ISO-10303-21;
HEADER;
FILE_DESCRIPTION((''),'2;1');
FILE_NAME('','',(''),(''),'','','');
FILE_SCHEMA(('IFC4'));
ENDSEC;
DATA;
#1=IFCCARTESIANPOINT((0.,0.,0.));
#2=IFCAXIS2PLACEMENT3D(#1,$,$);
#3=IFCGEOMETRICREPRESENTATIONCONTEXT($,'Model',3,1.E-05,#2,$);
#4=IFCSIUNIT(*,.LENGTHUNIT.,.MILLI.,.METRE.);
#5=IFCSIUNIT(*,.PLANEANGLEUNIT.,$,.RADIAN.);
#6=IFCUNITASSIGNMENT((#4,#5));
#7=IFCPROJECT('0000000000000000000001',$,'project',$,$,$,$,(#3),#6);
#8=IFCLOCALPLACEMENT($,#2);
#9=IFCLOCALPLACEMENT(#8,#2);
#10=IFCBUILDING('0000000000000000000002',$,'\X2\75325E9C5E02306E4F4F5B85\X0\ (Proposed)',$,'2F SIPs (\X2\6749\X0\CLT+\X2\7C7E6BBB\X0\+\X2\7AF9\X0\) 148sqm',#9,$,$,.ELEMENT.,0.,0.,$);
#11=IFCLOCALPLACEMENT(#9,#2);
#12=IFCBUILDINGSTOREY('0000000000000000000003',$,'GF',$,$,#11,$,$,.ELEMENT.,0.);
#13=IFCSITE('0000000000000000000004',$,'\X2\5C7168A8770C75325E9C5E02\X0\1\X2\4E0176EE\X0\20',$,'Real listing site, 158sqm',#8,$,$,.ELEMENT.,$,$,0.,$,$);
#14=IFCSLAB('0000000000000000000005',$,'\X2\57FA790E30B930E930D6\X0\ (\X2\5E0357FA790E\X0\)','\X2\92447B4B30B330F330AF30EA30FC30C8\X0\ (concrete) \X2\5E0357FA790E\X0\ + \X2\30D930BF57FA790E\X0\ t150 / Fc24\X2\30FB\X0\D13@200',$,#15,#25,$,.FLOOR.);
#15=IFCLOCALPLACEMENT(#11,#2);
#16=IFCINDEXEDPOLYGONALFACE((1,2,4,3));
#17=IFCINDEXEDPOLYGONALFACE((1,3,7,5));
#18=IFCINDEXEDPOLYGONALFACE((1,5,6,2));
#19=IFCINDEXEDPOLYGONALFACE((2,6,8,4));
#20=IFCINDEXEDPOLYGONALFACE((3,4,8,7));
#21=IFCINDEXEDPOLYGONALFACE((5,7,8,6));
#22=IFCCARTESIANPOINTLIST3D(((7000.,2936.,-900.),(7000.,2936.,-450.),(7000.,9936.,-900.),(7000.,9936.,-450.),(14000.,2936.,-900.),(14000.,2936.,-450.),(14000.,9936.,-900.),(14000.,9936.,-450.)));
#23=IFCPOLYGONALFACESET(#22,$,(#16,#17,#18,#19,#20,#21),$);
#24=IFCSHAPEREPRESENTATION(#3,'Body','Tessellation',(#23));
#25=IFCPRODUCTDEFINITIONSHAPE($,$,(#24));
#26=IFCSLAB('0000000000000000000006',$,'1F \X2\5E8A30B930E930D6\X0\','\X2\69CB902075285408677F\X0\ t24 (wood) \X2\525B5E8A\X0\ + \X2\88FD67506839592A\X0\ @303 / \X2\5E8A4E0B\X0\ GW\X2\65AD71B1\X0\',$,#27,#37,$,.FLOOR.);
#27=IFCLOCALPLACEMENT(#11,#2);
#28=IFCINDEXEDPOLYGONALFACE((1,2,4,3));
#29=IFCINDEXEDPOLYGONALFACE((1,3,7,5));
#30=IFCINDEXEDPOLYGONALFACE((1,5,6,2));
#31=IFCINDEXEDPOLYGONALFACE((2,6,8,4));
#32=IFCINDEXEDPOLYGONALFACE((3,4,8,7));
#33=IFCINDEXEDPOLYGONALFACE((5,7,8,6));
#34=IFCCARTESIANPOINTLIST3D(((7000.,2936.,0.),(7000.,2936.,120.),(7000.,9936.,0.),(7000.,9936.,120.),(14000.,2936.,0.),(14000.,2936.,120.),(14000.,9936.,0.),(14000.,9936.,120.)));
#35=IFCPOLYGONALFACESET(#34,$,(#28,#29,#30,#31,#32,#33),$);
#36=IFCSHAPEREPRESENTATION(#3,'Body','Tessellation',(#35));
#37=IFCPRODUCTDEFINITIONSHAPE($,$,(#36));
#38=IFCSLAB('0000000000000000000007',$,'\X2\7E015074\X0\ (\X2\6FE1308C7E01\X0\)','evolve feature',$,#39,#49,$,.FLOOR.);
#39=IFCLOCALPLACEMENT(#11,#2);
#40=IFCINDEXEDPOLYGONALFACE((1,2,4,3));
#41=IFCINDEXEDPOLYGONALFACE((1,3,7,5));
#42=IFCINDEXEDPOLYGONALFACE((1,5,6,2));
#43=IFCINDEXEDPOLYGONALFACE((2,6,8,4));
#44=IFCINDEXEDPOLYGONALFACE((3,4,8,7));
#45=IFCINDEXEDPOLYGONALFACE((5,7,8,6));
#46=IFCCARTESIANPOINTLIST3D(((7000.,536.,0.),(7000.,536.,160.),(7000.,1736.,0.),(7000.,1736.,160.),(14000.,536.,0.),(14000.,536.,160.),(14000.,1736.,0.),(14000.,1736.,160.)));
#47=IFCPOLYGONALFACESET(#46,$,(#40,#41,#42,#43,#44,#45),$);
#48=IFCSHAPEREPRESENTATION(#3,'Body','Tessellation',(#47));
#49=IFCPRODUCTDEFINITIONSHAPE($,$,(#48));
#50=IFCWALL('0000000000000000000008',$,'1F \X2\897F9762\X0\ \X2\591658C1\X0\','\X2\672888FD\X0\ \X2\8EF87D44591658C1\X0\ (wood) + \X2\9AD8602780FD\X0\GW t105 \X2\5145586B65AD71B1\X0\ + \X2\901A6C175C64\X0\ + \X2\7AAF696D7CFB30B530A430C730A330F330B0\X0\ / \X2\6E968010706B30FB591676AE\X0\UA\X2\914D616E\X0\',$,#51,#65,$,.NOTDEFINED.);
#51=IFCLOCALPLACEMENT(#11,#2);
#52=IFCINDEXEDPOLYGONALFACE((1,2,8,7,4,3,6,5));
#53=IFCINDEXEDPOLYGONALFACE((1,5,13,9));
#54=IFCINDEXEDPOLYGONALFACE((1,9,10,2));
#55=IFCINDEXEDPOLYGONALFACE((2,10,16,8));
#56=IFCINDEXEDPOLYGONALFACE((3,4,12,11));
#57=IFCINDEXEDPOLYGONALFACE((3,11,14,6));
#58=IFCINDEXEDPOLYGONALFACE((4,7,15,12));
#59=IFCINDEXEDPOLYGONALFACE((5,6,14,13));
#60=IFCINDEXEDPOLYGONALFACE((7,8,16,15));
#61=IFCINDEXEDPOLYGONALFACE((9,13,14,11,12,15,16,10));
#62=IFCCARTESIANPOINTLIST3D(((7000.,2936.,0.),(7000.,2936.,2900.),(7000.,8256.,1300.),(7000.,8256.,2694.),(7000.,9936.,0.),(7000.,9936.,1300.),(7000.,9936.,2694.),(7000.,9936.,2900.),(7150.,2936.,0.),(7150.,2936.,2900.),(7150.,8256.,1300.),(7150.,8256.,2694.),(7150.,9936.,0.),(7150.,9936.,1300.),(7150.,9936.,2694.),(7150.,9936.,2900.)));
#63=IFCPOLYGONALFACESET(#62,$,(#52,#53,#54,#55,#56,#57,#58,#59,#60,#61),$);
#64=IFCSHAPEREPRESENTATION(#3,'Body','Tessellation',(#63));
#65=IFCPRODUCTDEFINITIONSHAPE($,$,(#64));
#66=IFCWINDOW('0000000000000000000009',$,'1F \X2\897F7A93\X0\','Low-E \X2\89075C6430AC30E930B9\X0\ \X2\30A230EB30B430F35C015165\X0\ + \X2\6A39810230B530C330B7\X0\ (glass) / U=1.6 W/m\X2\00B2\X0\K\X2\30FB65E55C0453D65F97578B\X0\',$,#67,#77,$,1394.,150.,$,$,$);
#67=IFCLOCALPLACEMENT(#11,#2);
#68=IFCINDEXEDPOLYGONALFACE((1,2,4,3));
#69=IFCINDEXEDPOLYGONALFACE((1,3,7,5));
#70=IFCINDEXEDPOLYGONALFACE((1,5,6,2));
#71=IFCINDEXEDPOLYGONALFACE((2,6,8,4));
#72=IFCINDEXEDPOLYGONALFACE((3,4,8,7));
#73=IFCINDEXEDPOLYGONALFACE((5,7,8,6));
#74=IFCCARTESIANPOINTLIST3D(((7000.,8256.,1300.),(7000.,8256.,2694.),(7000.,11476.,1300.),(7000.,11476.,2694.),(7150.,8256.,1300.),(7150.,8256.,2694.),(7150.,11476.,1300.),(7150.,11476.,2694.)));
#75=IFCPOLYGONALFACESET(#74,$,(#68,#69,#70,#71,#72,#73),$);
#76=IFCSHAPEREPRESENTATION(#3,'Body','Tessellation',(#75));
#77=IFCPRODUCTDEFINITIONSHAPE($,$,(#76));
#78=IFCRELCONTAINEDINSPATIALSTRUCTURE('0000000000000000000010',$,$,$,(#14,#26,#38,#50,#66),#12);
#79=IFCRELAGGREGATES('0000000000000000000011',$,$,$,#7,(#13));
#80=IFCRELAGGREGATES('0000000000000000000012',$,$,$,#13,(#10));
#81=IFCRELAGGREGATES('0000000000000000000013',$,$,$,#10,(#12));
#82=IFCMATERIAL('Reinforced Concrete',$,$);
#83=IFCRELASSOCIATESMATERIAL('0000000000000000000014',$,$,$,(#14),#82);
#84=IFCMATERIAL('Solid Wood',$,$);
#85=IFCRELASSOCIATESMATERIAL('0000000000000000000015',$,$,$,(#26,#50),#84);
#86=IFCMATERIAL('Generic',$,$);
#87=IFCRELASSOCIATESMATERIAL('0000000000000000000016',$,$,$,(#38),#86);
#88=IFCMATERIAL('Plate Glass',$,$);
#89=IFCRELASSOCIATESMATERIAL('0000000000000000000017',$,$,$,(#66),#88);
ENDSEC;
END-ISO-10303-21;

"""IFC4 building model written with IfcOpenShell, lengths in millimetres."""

from ifc_helpers import new_model, si_unit, frame, frame_2d, origin, place, context, project, spatial, rectangle, extrude, material, element, fill, save


model = new_model("IFC4")

# Units and contexts
model_context = context("Model", 3, precision=1e-05, world=origin())
ifc_project = project(units=[si_unit("LENGTHUNIT", "METRE", prefix="MILLI"), si_unit("PLANEANGLEUNIT", "RADIAN")], contexts=[model_context])

# Site, building, storey
site_placement = place(None, origin())
site = spatial("IfcSite", under=ifc_project, at=site_placement, Name="山梨県甲府市1丁目20", ObjectType="Real listing site, 158sqm", CompositionType="ELEMENT", RefElevation=0.0)
building_placement = place(site_placement, origin())
building = spatial("IfcBuilding", under=site, at=building_placement, Name="甲府市の住宅 (Proposed)", ObjectType="2F SIPs (杉CLT+籾殻+竹) 148sqm", CompositionType="ELEMENT", ElevationOfRefHeight=0.0, ElevationOfTerrain=0.0)
storey_placement = place(building_placement, origin())
storey = spatial("IfcBuildingStorey", under=building, at=storey_placement, Name="GF", CompositionType="ELEMENT", Elevation=0.0)

# Slabs
ifc_material_1 = material(Name="Reinforced Concrete")
slab_1_placement = place(storey_placement, frame((3500.0, 1468.0, -450.0)))
element("IfcSlab", 1, at=slab_1_placement, inside=storey, material=ifc_material_1, Name="基礎スラブ (布基礎)", Description="鉄筋コンクリート (concrete) 布基礎 + ベタ基礎 t150 / Fc24・D13@200", PredefinedType="FLOOR", context=model_context, shape_type="SweptSolid", body=[
    extrude(rectangle(XDim=7000.0, YDim=7000.0, at=frame_2d((3500.0, 3500.0))), frame((3500.0, 1468.0, -450.0)), (0.0, 0.0, 1.0), 450.0),
])
ifc_material_2 = material(Name="Solid Wood")
slab_2_placement = place(storey_placement, frame((3500.0, 1468.0, 0.0)))
element("IfcSlab", 2, at=slab_2_placement, inside=storey, material=ifc_material_2, Name="1F 床スラブ", Description="構造用合板 t24 (wood) 剛床 + 製材根太 @303 / 床下 GW断熱", PredefinedType="FLOOR", context=model_context, shape_type="SweptSolid", body=[
    extrude(rectangle(XDim=7000.0, YDim=7000.0, at=frame_2d((3500.0, 3500.0))), frame((3500.0, 1468.0, 0.0)), (0.0, 0.0, 1.0), 120.0),
])
ifc_material_3 = material(Name="Generic")
slab_3_placement = place(storey_placement, frame((3500.0, 268.0, 0.0)))
element("IfcSlab", 3, at=slab_3_placement, inside=storey, material=ifc_material_3, Name="縁側 (濡れ縁)", Description="evolve feature", PredefinedType="FLOOR", context=model_context, shape_type="SweptSolid", body=[
    extrude(rectangle(XDim=7000.0, YDim=1200.0, at=frame_2d((3500.0, 600.0))), frame((3500.0, 268.0, 0.0)), (0.0, 0.0, 1.0), 160.0),
])

# Shared definitions
ifc_material_4 = material(Name="Plate Glass")

# Wall, opening, window
wall_1_placement = place(storey_placement, frame((3500.0, 1468.0, 0.0)))
wall_1 = element("IfcWall", 4, at=wall_1_placement, inside=storey, material=ifc_material_2, Name="1F 西面 外壁", Description="木製 軸組外壁 (wood) + 高性能GW t105 充填断熱 + 通気層 + 窯業系サイディング / 準耐火・外皮UA配慮", PredefinedType="NOTDEFINED", context=model_context, shape_type="SweptSolid", body=[
    extrude(rectangle(XDim=150.0, YDim=7000.0, at=frame_2d((75.0, 3500.0))), frame((3500.0, 1468.0, 0.0)), (0.0, 0.0, 1.0), 2900.0),
])
opening_1_placement = place(storey_placement, frame((3500.0, 4128.0, 650.0)))
opening_1 = element("IfcOpeningElement", 5, at=opening_1_placement, cuts=wall_1, PredefinedType="NOTDEFINED", context=model_context, shape_type="SweptSolid", body=[
    extrude(rectangle(XDim=150.0, YDim=3220.0, at=frame_2d((75.0, 1610.0))), frame((3500.0, 4128.0, 650.0)), (0.0, 0.0, 1.0), 1394.0),
])
window_1_placement = place(storey_placement, frame((3500.0, 4128.0, 650.0)))
window_1 = element("IfcWindow", 6, at=window_1_placement, inside=storey, material=ifc_material_4, Name="1F 西窓", Description="Low-E 複層ガラス アルゴン封入 + 樹脂サッシ (glass) / U=1.6 W/m²K・日射取得型", OverallHeight=1394.0, OverallWidth=150.0, context=model_context, shape_type="SweptSolid", body=[
    extrude(rectangle(XDim=150.0, YDim=3220.0, at=frame_2d((75.0, 1610.0))), frame((3500.0, 4128.0, 650.0)), (0.0, 0.0, 1.0), 1394.0),
])
fill(opening_1, window_1)

save(model, "model.ifc")
